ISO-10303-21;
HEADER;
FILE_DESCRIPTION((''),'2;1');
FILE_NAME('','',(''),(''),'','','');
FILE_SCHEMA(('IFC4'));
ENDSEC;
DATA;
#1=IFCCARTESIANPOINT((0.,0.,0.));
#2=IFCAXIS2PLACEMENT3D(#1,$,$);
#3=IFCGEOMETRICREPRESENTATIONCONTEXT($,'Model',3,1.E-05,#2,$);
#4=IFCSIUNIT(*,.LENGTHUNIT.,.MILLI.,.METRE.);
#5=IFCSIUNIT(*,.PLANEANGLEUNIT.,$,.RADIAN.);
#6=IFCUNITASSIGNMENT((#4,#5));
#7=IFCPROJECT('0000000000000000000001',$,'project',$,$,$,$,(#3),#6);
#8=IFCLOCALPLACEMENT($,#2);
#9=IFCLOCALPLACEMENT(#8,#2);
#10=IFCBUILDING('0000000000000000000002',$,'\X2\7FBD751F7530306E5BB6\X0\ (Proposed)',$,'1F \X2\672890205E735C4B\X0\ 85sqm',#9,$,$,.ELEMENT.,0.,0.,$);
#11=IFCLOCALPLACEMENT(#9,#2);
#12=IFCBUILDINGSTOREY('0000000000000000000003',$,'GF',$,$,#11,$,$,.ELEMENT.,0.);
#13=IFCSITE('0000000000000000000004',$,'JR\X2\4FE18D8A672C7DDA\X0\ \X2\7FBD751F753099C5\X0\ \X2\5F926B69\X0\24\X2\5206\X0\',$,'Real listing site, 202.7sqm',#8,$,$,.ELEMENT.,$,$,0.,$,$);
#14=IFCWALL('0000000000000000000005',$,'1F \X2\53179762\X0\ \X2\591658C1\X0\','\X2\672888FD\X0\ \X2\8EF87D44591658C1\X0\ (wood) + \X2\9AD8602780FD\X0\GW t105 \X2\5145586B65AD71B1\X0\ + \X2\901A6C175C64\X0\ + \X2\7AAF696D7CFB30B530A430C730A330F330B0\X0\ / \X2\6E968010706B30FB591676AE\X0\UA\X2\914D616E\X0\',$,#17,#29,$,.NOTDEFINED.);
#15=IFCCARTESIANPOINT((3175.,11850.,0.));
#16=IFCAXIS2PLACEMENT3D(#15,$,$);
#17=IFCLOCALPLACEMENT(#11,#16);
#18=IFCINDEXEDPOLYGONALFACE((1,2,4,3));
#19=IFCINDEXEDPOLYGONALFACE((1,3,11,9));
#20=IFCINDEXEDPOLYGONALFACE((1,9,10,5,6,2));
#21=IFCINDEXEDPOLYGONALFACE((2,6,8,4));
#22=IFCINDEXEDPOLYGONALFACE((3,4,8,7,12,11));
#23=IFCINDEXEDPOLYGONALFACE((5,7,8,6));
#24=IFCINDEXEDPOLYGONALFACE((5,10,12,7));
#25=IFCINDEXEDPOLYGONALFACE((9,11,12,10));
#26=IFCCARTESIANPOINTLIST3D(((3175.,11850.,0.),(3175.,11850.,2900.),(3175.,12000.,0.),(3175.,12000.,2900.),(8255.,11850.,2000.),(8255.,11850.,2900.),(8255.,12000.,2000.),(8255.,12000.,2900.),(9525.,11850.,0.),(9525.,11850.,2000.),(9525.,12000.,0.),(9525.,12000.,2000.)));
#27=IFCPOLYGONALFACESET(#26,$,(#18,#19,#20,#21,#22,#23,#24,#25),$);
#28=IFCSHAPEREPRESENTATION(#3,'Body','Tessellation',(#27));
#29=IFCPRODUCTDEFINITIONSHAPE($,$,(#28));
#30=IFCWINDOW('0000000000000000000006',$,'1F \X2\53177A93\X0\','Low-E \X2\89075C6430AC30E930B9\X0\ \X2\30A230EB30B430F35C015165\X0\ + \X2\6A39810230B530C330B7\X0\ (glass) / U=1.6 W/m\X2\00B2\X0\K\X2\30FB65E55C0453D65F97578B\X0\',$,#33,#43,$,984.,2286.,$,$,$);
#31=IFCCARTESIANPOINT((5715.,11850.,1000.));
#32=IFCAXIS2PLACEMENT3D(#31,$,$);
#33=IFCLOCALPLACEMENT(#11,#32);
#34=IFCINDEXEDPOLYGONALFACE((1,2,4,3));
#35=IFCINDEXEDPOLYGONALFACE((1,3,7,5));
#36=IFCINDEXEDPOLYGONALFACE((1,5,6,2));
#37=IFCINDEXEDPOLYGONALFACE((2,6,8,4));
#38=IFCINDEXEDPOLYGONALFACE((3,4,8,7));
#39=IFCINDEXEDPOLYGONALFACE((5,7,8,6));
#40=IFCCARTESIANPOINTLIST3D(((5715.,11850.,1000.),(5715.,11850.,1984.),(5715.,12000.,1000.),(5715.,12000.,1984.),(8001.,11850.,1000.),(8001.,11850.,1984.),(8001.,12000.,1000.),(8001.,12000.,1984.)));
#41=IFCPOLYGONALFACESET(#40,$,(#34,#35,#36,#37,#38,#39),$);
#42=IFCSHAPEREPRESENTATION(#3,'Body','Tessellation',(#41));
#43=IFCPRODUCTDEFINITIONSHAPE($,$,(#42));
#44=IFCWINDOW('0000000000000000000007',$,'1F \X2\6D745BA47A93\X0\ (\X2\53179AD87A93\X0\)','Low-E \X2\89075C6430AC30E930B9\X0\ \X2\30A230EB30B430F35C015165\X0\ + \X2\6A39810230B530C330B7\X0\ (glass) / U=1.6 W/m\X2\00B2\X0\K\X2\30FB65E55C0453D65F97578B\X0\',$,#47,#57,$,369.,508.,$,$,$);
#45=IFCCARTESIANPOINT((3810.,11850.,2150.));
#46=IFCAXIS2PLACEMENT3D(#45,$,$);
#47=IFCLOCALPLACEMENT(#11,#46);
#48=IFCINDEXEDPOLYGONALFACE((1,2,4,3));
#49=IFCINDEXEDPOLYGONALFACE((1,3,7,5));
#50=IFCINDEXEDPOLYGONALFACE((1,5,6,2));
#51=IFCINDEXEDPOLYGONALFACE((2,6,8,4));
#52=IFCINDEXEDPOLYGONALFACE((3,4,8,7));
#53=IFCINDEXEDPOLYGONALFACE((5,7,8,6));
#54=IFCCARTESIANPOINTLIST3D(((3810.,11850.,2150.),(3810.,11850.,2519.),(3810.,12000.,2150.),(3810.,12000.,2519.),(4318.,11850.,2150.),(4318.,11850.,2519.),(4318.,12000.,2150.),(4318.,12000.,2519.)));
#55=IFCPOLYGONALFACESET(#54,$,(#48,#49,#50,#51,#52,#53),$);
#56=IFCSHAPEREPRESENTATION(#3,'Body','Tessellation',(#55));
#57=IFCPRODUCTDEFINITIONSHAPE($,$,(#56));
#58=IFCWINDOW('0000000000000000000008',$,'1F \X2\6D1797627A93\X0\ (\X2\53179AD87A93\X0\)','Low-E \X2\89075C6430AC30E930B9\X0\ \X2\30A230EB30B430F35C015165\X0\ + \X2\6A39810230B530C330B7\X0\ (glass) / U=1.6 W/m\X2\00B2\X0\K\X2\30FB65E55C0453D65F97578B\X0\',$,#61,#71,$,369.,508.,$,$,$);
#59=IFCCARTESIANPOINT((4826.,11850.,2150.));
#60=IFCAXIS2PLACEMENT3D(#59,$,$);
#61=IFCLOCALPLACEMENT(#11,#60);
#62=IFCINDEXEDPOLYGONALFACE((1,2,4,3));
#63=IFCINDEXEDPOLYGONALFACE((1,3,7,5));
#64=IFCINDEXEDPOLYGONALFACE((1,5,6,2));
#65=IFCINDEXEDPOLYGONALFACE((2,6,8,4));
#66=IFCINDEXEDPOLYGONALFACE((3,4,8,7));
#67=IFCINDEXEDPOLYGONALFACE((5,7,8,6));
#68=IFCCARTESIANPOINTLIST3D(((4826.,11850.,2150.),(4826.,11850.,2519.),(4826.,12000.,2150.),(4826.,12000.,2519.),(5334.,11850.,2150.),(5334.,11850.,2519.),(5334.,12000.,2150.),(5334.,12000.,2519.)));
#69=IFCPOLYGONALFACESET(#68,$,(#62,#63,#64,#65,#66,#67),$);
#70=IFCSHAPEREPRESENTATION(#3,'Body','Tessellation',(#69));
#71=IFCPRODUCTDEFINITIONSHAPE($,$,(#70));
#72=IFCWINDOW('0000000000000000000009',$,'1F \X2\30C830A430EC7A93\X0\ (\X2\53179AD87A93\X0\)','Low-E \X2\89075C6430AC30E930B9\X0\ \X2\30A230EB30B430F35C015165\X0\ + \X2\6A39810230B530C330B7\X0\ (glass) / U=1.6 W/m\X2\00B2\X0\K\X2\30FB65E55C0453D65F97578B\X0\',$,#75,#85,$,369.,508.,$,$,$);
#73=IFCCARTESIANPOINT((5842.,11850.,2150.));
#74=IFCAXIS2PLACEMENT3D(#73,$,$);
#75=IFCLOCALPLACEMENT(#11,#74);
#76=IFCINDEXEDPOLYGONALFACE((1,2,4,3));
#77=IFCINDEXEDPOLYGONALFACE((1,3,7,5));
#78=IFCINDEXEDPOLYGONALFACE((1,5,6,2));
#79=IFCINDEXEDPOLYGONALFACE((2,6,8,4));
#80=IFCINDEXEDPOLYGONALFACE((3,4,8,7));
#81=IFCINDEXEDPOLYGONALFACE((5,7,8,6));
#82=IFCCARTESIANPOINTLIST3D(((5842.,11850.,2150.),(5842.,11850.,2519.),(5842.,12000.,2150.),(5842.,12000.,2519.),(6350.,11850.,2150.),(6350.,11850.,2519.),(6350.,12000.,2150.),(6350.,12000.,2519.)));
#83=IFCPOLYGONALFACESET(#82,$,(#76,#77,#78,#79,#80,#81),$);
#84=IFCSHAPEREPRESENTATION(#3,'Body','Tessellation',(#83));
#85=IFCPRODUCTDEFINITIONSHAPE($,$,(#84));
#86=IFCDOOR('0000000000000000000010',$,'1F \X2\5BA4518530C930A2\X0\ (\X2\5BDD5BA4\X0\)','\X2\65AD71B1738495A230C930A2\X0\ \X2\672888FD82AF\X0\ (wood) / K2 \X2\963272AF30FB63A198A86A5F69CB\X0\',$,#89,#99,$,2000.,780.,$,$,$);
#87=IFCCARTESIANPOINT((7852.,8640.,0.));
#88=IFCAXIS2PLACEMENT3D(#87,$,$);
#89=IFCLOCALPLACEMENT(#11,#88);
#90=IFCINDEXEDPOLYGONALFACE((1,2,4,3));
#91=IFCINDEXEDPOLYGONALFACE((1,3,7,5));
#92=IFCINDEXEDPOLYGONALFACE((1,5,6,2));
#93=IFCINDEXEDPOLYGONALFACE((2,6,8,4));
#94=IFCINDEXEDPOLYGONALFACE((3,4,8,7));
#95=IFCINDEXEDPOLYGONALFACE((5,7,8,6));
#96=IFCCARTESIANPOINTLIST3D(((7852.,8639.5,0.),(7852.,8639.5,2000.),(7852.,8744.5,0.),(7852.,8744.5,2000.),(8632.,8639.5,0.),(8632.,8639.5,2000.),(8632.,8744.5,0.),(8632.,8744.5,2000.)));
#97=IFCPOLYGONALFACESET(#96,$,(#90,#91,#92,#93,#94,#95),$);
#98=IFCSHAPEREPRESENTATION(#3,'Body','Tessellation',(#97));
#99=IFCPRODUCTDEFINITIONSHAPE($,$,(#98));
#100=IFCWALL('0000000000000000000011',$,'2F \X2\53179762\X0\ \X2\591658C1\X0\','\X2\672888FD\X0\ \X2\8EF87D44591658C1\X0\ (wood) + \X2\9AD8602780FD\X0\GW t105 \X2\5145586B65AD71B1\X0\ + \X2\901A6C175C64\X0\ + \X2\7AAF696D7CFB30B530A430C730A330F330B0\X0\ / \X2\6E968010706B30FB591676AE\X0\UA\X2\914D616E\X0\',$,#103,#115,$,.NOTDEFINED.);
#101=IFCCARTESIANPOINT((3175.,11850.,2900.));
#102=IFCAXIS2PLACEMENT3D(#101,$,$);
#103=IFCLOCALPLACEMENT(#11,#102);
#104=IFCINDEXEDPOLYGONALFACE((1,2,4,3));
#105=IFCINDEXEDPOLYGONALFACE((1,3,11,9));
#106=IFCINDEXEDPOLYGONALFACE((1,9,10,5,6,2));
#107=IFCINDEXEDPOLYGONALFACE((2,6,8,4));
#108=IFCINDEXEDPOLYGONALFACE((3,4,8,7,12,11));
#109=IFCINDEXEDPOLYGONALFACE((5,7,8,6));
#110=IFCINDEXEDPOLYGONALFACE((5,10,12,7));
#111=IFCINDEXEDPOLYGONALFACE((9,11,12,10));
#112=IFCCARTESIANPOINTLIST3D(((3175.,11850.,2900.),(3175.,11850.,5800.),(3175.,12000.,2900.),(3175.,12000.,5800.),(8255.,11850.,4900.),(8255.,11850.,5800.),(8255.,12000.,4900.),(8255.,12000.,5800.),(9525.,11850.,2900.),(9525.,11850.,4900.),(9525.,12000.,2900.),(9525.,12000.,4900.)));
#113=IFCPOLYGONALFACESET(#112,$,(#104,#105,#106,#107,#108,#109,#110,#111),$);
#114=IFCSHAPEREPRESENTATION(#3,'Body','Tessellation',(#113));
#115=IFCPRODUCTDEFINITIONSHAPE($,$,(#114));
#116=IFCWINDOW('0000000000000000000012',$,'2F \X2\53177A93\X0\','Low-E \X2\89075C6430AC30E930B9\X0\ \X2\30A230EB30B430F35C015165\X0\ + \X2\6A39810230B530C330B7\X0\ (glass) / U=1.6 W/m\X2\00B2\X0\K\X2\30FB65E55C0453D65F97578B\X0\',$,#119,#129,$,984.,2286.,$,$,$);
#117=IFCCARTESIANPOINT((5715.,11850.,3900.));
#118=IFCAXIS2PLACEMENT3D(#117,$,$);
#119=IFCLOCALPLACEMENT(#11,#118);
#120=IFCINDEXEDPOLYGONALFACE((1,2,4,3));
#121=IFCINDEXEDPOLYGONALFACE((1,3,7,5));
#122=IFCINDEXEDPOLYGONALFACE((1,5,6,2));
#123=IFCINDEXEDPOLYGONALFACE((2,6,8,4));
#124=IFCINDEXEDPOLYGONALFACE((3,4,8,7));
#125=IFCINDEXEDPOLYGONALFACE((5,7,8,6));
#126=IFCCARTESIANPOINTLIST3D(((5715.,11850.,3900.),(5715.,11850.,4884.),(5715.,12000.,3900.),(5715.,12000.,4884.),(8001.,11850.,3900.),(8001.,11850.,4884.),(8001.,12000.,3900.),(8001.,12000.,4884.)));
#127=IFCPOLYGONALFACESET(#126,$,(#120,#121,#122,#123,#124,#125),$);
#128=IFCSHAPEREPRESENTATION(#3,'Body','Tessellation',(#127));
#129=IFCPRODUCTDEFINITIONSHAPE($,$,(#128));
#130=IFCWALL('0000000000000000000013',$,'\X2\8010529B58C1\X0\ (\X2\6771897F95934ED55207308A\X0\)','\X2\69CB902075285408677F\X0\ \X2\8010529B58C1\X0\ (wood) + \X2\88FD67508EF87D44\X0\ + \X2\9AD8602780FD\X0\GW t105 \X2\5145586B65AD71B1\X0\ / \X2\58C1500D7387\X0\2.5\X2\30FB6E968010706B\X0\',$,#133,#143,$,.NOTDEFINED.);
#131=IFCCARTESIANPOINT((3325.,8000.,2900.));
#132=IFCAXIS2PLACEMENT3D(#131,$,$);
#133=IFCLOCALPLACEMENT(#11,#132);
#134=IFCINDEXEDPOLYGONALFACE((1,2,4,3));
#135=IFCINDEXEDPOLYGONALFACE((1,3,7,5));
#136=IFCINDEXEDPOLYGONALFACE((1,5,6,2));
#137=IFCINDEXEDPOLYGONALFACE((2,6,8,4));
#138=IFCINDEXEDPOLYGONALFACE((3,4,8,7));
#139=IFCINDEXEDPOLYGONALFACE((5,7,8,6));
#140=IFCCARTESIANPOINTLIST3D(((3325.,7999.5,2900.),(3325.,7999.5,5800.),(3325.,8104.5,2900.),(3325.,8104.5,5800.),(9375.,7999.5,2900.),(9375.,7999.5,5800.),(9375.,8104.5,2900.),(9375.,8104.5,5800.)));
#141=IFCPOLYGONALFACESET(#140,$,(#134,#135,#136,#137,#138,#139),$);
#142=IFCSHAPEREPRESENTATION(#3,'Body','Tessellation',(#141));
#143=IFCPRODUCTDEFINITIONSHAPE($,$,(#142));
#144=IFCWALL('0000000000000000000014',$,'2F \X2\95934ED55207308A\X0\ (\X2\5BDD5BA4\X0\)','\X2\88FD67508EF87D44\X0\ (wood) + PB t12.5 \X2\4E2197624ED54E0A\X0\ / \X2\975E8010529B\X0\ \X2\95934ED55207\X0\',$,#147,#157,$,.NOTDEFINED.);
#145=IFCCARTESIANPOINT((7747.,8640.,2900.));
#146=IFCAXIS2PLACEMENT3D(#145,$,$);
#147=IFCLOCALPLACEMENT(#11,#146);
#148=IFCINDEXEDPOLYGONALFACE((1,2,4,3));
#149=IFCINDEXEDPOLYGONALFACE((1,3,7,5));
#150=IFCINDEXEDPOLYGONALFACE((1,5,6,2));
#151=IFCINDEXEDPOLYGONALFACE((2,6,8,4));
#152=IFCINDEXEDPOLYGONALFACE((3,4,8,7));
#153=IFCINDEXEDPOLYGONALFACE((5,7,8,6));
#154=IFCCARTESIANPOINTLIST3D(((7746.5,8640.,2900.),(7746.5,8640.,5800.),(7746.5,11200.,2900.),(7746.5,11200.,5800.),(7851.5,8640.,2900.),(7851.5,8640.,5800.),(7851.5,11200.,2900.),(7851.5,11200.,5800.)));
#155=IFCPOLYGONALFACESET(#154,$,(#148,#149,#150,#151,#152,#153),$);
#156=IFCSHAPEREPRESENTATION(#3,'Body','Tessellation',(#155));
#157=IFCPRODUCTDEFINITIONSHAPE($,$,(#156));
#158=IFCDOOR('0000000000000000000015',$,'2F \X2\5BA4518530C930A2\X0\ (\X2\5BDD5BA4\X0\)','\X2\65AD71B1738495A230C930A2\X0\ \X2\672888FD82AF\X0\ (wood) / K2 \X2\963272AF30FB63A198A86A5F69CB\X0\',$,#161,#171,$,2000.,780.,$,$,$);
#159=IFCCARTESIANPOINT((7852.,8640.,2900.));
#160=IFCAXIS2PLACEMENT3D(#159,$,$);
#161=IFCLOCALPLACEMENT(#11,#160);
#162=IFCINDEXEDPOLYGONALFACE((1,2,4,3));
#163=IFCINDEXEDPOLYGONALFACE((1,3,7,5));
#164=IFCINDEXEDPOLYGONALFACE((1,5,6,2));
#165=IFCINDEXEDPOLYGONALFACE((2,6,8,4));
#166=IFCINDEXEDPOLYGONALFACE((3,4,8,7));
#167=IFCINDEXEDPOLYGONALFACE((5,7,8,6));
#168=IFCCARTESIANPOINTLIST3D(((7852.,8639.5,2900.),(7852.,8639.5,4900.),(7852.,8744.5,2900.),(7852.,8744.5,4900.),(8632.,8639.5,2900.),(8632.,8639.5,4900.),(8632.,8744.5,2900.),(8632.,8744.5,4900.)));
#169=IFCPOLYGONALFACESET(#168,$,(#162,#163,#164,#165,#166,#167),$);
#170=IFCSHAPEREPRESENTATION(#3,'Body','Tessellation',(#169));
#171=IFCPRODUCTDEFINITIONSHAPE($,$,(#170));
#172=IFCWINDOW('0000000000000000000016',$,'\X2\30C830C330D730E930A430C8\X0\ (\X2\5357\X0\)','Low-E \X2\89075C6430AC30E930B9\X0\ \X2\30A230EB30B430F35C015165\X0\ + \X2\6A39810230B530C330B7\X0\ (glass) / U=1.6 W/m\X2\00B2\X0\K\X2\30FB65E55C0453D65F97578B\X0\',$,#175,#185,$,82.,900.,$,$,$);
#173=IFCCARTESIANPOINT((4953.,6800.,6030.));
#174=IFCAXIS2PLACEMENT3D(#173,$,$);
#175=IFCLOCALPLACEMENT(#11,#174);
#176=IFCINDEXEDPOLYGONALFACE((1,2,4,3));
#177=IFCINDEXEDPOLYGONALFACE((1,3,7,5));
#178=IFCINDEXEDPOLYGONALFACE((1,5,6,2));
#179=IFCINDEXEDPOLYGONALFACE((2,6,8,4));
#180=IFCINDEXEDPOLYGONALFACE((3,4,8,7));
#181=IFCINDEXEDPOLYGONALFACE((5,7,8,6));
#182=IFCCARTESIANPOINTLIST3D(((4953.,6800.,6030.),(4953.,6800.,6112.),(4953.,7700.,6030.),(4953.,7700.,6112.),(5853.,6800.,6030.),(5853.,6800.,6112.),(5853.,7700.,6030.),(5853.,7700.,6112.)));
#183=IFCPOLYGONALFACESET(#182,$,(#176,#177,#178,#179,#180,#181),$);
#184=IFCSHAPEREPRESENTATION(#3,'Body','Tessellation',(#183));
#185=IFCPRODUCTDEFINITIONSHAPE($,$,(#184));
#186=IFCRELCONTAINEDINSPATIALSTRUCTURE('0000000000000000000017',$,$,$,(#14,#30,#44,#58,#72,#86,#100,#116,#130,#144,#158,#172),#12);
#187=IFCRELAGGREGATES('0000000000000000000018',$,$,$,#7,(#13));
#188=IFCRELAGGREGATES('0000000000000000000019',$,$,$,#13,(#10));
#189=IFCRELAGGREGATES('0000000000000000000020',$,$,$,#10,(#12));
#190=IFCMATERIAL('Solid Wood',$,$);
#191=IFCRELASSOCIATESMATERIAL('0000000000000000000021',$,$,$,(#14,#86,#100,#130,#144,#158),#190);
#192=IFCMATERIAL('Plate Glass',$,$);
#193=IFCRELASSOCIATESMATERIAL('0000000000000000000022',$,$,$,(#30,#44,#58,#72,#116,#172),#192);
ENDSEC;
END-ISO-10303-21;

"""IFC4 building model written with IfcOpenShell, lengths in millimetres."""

from ifc_helpers import new_model, si_unit, frame, frame_2d, origin, place, context, project, spatial, rectangle, extrude, material, element, fill, save


model = new_model("IFC4")

# Units and contexts
model_context = context("Model", 3, precision=1e-05, world=origin())
ifc_project = project(units=[si_unit("LENGTHUNIT", "METRE", prefix="MILLI"), si_unit("PLANEANGLEUNIT", "RADIAN")], contexts=[model_context])

# Site, building, storey
site_placement = place(None, origin())
site = spatial("IfcSite", under=ifc_project, at=site_placement, Name="JR信越本線 羽生田駅 徒歩24分", ObjectType="Real listing site, 202.7sqm", CompositionType="ELEMENT", RefElevation=0.0)
building_placement = place(site_placement, origin())
building = spatial("IfcBuilding", under=site, at=building_placement, Name="羽生田の家 (Proposed)", ObjectType="1F 木造平屋 85sqm", CompositionType="ELEMENT", ElevationOfRefHeight=0.0, ElevationOfTerrain=0.0)
storey_placement = place(building_placement, origin())
storey = spatial("IfcBuildingStorey", under=building, at=storey_placement, Name="GF", CompositionType="ELEMENT", Elevation=0.0)

# Wall, openings, windows
ifc_material_1 = material(Name="Solid Wood")
wall_1_placement = place(storey_placement, frame((3175.0, 11850.0, 0.0)))
wall_1 = element("IfcWall", 1, at=wall_1_placement, inside=storey, material=ifc_material_1, Name="1F 北面 外壁", Description="木製 軸組外壁 (wood) + 高性能GW t105 充填断熱 + 通気層 + 窯業系サイディング / 準耐火・外皮UA配慮", PredefinedType="NOTDEFINED", context=model_context, shape_type="SweptSolid", body=[
    extrude(rectangle(XDim=6350.0, YDim=150.0, at=frame_2d((3175.0, 75.0))), frame((3175.0, 11850.0, 0.0)), (0.0, 0.0, 1.0), 2900.0),
])
opening_1_placement = place(storey_placement, frame((5715.0, 11850.0, 1000.0)))
opening_1 = element("IfcOpeningElement", 2, at=opening_1_placement, cuts=wall_1, PredefinedType="NOTDEFINED", context=model_context, shape_type="SweptSolid", body=[
    extrude(rectangle(XDim=2286.0, YDim=150.0, at=frame_2d((1143.0, 75.0))), frame((5715.0, 11850.0, 1000.0)), (0.0, 0.0, 1.0), 984.0),
])
opening_2_placement = place(storey_placement, frame((3810.0, 11850.0, 2150.0)))
opening_2 = element("IfcOpeningElement", 3, at=opening_2_placement, cuts=wall_1, PredefinedType="NOTDEFINED", context=model_context, shape_type="SweptSolid", body=[
    extrude(rectangle(XDim=508.0, YDim=150.0, at=frame_2d((254.0, 75.0))), frame((3810.0, 11850.0, 2150.0)), (0.0, 0.0, 1.0), 369.0),
])
opening_3_placement = place(storey_placement, frame((4826.0, 11850.0, 2150.0)))
opening_3 = element("IfcOpeningElement", 4, at=opening_3_placement, cuts=wall_1, PredefinedType="NOTDEFINED", context=model_context, shape_type="SweptSolid", body=[
    extrude(rectangle(XDim=508.0, YDim=150.0, at=frame_2d((254.0, 75.0))), frame((4826.0, 11850.0, 2150.0)), (0.0, 0.0, 1.0), 369.0),
])
opening_4_placement = place(storey_placement, frame((5842.0, 11850.0, 2150.0)))
opening_4 = element("IfcOpeningElement", 5, at=opening_4_placement, cuts=wall_1, PredefinedType="NOTDEFINED", context=model_context, shape_type="SweptSolid", body=[
    extrude(rectangle(XDim=508.0, YDim=150.0, at=frame_2d((254.0, 75.0))), frame((5842.0, 11850.0, 2150.0)), (0.0, 0.0, 1.0), 369.0),
])
ifc_material_2 = material(Name="Plate Glass")
window_1_placement = place(storey_placement, frame((5715.0, 11850.0, 1000.0)))
window_1 = element("IfcWindow", 6, at=window_1_placement, inside=storey, material=ifc_material_2, Name="1F 北窓", Description="Low-E 複層ガラス アルゴン封入 + 樹脂サッシ (glass) / U=1.6 W/m²K・日射取得型", OverallHeight=984.0, OverallWidth=2286.0, context=model_context, shape_type="SweptSolid", body=[
    extrude(rectangle(XDim=2286.0, YDim=150.0, at=frame_2d((1143.0, 75.0))), frame((5715.0, 11850.0, 1000.0)), (0.0, 0.0, 1.0), 984.0),
])
fill(opening_1, window_1)
window_2_placement = place(storey_placement, frame((3810.0, 11850.0, 2150.0)))
window_2 = element("IfcWindow", 7, at=window_2_placement, inside=storey, material=ifc_material_2, Name="1F 浴室窓 (北高窓)", Description="Low-E 複層ガラス アルゴン封入 + 樹脂サッシ (glass) / U=1.6 W/m²K・日射取得型", OverallHeight=369.0, OverallWidth=508.0, context=model_context, shape_type="SweptSolid", body=[
    extrude(rectangle(XDim=508.0, YDim=150.0, at=frame_2d((254.0, 75.0))), frame((3810.0, 11850.0, 2150.0)), (0.0, 0.0, 1.0), 369.0),
])
fill(opening_2, window_2)
window_3_placement = place(storey_placement, frame((4826.0, 11850.0, 2150.0)))
window_3 = element("IfcWindow", 8, at=window_3_placement, inside=storey, material=ifc_material_2, Name="1F 洗面窓 (北高窓)", Description="Low-E 複層ガラス アルゴン封入 + 樹脂サッシ (glass) / U=1.6 W/m²K・日射取得型", OverallHeight=369.0, OverallWidth=508.0, context=model_context, shape_type="SweptSolid", body=[
    extrude(rectangle(XDim=508.0, YDim=150.0, at=frame_2d((254.0, 75.0))), frame((4826.0, 11850.0, 2150.0)), (0.0, 0.0, 1.0), 369.0),
])
fill(opening_3, window_3)
window_4_placement = place(storey_placement, frame((5842.0, 11850.0, 2150.0)))
window_4 = element("IfcWindow", 9, at=window_4_placement, inside=storey, material=ifc_material_2, Name="1F トイレ窓 (北高窓)", Description="Low-E 複層ガラス アルゴン封入 + 樹脂サッシ (glass) / U=1.6 W/m²K・日射取得型", OverallHeight=369.0, OverallWidth=508.0, context=model_context, shape_type="SweptSolid", body=[
    extrude(rectangle(XDim=508.0, YDim=150.0, at=frame_2d((254.0, 75.0))), frame((5842.0, 11850.0, 2150.0)), (0.0, 0.0, 1.0), 369.0),
])
fill(opening_4, window_4)

# Door
door_1_placement = place(storey_placement, frame((7852.0, 8640.0, 0.0)))
element("IfcDoor", 10, at=door_1_placement, inside=storey, material=ifc_material_1, Name="1F 室内ドア (寝室)", Description="断熱玄関ドア 木製芯 (wood) / K2 防犯・採風機構", OverallHeight=2000.0, OverallWidth=780.0, context=model_context, shape_type="SweptSolid", body=[
    extrude(rectangle(XDim=780.0, YDim=105.0, at=frame_2d((390.0, 52.0))), frame((7852.0, 8640.0, 0.0)), (0.0, 0.0, 1.0), 2000.0),
])

# Wall, opening, window
wall_2_placement = place(storey_placement, frame((3175.0, 11850.0, 2900.0)))
wall_2 = element("IfcWall", 11, at=wall_2_placement, inside=storey, material=ifc_material_1, Name="2F 北面 外壁", Description="木製 軸組外壁 (wood) + 高性能GW t105 充填断熱 + 通気層 + 窯業系サイディング / 準耐火・外皮UA配慮", PredefinedType="NOTDEFINED", context=model_context, shape_type="SweptSolid", body=[
    extrude(rectangle(XDim=6350.0, YDim=150.0, at=frame_2d((3175.0, 75.0))), frame((3175.0, 11850.0, 2900.0)), (0.0, 0.0, 1.0), 2900.0),
])
opening_5_placement = place(storey_placement, frame((5715.0, 11850.0, 3900.0)))
opening_5 = element("IfcOpeningElement", 12, at=opening_5_placement, cuts=wall_2, PredefinedType="NOTDEFINED", context=model_context, shape_type="SweptSolid", body=[
    extrude(rectangle(XDim=2286.0, YDim=150.0, at=frame_2d((1143.0, 75.0))), frame((5715.0, 11850.0, 3900.0)), (0.0, 0.0, 1.0), 984.0),
])
window_5_placement = place(storey_placement, frame((5715.0, 11850.0, 3900.0)))
window_5 = element("IfcWindow", 13, at=window_5_placement, inside=storey, material=ifc_material_2, Name="2F 北窓", Description="Low-E 複層ガラス アルゴン封入 + 樹脂サッシ (glass) / U=1.6 W/m²K・日射取得型", OverallHeight=984.0, OverallWidth=2286.0, context=model_context, shape_type="SweptSolid", body=[
    extrude(rectangle(XDim=2286.0, YDim=150.0, at=frame_2d((1143.0, 75.0))), frame((5715.0, 11850.0, 3900.0)), (0.0, 0.0, 1.0), 984.0),
])
fill(opening_5, window_5)

# Walls
wall_3_placement = place(storey_placement, frame((3325.0, 8000.0, 2900.0)))
element("IfcWall", 14, at=wall_3_placement, inside=storey, material=ifc_material_1, Name="耐力壁 (東西間仕切り)", Description="構造用合板 耐力壁 (wood) + 製材軸組 + 高性能GW t105 充填断熱 / 壁倍率2.5・準耐火", PredefinedType="NOTDEFINED", context=model_context, shape_type="SweptSolid", body=[
    extrude(rectangle(XDim=6050.0, YDim=105.0, at=frame_2d((3025.0, 52.0))), frame((3325.0, 8000.0, 2900.0)), (0.0, 0.0, 1.0), 2900.0),
])
wall_4_placement = place(storey_placement, frame((7747.0, 8640.0, 2900.0)))
element("IfcWall", 15, at=wall_4_placement, inside=storey, material=ifc_material_1, Name="2F 間仕切り (寝室)", Description="製材軸組 (wood) + PB t12.5 両面仕上 / 非耐力 間仕切", PredefinedType="NOTDEFINED", context=model_context, shape_type="SweptSolid", body=[
    extrude(rectangle(XDim=105.0, YDim=2560.0, at=frame_2d((52.0, 1280.0))), frame((7747.0, 8640.0, 2900.0)), (0.0, 0.0, 1.0), 2900.0),
])

# Door
door_2_placement = place(storey_placement, frame((7852.0, 8640.0, 2900.0)))
element("IfcDoor", 16, at=door_2_placement, inside=storey, material=ifc_material_1, Name="2F 室内ドア (寝室)", Description="断熱玄関ドア 木製芯 (wood) / K2 防犯・採風機構", OverallHeight=2000.0, OverallWidth=780.0, context=model_context, shape_type="SweptSolid", body=[
    extrude(rectangle(XDim=780.0, YDim=105.0, at=frame_2d((390.0, 52.0))), frame((7852.0, 8640.0, 2900.0)), (0.0, 0.0, 1.0), 2000.0),
])

# Window
window_6_placement = place(storey_placement, frame((4953.0, 6800.0, 6030.0)))
element("IfcWindow", 17, at=window_6_placement, inside=storey, material=ifc_material_2, Name="トップライト (南)", Description="Low-E 複層ガラス アルゴン封入 + 樹脂サッシ (glass) / U=1.6 W/m²K・日射取得型", OverallHeight=82.0, OverallWidth=900.0, context=model_context, shape_type="SweptSolid", body=[
    extrude(rectangle(XDim=900.0, YDim=900.0, at=frame_2d((450.0, 450.0))), frame((4953.0, 6800.0, 6030.0)), (0.0, 0.0, 1.0), 82.0),
])

save(model, "model.ifc")
